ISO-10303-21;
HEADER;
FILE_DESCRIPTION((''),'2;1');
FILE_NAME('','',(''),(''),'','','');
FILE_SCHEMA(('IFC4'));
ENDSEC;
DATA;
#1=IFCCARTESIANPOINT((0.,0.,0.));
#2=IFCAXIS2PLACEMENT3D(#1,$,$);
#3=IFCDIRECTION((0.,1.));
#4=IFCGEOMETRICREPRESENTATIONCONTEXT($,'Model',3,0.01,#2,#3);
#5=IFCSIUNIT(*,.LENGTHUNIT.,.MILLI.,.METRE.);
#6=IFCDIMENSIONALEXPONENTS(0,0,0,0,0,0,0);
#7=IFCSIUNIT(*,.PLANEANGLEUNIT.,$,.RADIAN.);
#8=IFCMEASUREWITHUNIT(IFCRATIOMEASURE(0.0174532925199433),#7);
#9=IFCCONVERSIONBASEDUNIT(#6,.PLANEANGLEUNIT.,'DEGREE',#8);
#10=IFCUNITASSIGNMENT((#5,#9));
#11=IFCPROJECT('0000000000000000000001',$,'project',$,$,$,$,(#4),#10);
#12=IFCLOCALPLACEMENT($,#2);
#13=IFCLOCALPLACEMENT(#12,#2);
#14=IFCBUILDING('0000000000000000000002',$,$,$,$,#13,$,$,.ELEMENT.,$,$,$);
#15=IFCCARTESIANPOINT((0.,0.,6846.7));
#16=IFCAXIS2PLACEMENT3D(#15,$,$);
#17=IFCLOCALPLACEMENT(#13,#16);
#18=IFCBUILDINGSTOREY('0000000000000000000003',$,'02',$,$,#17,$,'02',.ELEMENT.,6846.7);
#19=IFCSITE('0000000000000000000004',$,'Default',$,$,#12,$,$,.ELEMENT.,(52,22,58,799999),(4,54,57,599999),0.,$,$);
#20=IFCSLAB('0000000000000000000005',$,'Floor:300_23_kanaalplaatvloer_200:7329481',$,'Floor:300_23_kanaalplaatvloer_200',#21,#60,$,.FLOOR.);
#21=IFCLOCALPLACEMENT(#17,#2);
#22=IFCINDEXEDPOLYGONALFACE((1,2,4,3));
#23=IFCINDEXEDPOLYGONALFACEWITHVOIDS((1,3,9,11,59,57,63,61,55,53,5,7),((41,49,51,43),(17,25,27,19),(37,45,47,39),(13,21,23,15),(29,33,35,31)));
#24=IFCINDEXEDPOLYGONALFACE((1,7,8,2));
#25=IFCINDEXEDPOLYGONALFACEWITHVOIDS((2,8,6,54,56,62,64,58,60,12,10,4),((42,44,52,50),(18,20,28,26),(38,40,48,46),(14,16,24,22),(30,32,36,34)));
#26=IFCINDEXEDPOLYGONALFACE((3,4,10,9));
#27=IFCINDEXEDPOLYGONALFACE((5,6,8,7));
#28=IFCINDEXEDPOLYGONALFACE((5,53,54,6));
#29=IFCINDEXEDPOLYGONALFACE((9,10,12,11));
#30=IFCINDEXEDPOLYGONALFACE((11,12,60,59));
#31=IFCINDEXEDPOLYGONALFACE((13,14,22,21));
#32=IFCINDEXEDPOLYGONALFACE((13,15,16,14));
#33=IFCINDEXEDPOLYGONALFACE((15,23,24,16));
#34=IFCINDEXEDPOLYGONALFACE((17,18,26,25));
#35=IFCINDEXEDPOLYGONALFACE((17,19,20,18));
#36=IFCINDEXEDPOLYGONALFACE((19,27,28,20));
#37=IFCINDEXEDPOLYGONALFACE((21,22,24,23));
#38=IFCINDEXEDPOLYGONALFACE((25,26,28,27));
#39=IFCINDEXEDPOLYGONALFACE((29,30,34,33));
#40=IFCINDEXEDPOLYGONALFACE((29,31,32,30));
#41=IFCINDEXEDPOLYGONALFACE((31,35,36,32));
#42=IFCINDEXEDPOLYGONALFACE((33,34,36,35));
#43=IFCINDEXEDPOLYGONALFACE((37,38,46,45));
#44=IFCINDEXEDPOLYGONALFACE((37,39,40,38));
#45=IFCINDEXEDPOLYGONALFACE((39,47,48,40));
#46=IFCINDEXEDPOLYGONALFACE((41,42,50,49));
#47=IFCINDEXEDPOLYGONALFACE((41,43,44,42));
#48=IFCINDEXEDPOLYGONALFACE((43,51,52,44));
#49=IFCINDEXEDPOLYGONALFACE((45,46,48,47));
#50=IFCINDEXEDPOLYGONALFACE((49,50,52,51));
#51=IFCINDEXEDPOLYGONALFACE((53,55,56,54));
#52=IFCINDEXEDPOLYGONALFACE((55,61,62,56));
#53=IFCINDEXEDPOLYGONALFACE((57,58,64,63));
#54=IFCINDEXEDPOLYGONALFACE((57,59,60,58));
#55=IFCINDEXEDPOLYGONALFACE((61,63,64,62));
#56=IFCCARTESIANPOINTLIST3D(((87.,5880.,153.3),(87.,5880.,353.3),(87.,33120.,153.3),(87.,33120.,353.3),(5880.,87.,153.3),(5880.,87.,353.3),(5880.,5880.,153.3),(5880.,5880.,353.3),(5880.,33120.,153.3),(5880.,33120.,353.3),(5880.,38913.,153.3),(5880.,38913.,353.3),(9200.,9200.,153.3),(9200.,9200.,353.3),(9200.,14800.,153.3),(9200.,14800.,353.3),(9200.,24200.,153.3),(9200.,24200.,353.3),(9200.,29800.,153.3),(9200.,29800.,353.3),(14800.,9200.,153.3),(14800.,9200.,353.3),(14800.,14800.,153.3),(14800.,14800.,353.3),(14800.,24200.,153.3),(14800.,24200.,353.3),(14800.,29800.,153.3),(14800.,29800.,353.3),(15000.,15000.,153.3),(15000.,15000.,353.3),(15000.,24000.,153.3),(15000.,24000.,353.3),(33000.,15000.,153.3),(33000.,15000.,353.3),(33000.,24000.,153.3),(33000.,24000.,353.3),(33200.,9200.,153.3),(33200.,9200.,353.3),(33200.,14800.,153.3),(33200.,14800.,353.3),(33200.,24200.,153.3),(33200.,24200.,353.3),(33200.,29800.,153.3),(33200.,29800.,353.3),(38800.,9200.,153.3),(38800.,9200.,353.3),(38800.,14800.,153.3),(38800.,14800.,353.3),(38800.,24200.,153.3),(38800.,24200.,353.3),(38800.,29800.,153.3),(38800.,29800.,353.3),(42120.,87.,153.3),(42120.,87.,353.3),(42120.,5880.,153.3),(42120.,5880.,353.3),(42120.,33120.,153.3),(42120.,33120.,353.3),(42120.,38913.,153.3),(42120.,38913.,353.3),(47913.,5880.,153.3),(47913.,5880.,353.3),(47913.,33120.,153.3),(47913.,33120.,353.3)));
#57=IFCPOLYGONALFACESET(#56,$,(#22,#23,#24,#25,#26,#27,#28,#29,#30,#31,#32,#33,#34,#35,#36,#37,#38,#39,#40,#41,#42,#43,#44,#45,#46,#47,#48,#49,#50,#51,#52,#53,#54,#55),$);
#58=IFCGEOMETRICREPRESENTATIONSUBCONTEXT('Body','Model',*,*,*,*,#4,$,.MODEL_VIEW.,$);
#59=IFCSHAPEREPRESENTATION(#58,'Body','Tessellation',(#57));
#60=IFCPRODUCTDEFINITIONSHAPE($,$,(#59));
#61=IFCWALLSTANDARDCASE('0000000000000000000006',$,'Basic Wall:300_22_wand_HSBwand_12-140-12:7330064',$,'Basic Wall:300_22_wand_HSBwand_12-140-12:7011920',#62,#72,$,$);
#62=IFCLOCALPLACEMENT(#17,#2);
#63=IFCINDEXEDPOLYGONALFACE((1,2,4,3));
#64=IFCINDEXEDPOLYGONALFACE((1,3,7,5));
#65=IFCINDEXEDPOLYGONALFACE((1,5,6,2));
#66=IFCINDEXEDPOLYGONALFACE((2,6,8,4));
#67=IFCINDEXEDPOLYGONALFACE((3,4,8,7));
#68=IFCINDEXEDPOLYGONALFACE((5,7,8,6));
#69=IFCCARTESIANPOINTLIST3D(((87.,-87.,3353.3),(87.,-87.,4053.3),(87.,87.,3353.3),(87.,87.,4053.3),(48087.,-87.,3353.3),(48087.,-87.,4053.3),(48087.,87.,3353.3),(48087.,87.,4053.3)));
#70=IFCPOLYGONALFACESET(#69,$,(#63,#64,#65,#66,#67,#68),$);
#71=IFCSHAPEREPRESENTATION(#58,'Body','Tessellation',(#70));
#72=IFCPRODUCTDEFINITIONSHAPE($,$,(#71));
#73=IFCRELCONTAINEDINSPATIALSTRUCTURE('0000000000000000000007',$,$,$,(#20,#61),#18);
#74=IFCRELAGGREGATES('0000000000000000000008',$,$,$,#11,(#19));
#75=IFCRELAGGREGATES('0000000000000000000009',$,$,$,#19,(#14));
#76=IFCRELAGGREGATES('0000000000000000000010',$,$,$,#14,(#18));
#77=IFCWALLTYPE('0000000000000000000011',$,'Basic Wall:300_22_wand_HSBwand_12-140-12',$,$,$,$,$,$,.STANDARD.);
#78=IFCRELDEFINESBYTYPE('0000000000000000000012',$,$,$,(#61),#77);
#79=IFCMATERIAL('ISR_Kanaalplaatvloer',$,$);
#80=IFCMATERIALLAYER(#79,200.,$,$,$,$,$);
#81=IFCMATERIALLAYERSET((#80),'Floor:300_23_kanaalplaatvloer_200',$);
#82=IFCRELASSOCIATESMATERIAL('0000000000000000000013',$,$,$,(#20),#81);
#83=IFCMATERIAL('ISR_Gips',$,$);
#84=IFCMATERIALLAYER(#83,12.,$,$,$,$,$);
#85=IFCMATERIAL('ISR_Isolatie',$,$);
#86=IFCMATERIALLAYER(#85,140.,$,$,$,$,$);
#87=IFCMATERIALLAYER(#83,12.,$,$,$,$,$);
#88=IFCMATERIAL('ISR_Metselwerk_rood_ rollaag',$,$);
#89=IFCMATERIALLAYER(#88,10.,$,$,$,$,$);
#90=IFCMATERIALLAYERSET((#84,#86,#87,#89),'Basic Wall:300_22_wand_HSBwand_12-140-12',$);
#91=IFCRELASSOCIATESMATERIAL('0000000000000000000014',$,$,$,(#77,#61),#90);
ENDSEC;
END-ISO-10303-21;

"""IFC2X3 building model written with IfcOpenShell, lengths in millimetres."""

from ifc_helpers import new_model, entity, si_unit, converted_unit, direction, frame, frame_2d, origin, origin_2d_with_axis, place, context, subcontext, project, spatial, polyline, rectangle, outline, extrude, material, layer, layer_set, layer_usage, type_object, element, save


model = new_model("IFC2X3")

# Units and contexts
model_context = context("Model", 3, precision=0.01, world=origin(), true_north=direction((0.0, 1.0)))
body_context = subcontext(model_context, "Body", "Model", "MODEL_VIEW")
ifc_project = project(units=[si_unit("LENGTHUNIT", "METRE", prefix="MILLI"), converted_unit("PLANEANGLEUNIT", "DEGREE", entity("IfcRatioMeasure", 0.0174532925199433), si_unit("PLANEANGLEUNIT", "RADIAN"), dimensions=[0, 0, 0, 0, 0, 0, 0])], contexts=[model_context])

# Site, building, storey
site_placement = place(None, origin())
site = spatial("IfcSite", under=ifc_project, at=site_placement, Name="Default", CompositionType="ELEMENT", RefLatitude=(52, 22, 58, 799999), RefLongitude=(4, 54, 57, 599999), RefElevation=0.0)
building_placement = place(site_placement, origin())
building = spatial("IfcBuilding", under=site, at=building_placement, CompositionType="ELEMENT")
storey_placement = place(building_placement, frame((0.0, 0.0, 6846.7)))
storey = spatial("IfcBuildingStorey", under=building, at=storey_placement, Name="02", LongName="02", CompositionType="ELEMENT", Elevation=6846.7)

# Slab, openings
ifc_material_1 = material(Name="ISR_Kanaalplaatvloer")
ifc_layer_1 = layer(ifc_material_1, 200.0)
ifc_layer_set_1 = layer_set([ifc_layer_1], Name="Floor:300_23_kanaalplaatvloer_200")
ifc_layer_usage_1 = layer_usage(ifc_layer_set_1, "AXIS3", "POSITIVE", 0.0)
slab_placement = place(storey_placement, frame((87.0, 87.0, 153.3)))
slab = element("IfcSlab", 1, at=slab_placement, inside=storey, material=ifc_layer_usage_1, Name="Floor:300_23_kanaalplaatvloer_200:7329481", ObjectType="Floor:300_23_kanaalplaatvloer_200", PredefinedType="FLOOR", context=body_context, shape_type="SweptSolid", body=[
    extrude(outline(polyline([(-18120.0, 19413.0), (-18120.0, 13620.0), (-23913.0, 13620.0), (-23913.0, -13620.0), (-18120.0, -13620.0), (-18120.0, -19413.0), (18120.0, -19413.0), (18120.0, -13620.0), (23913.0, -13620.0), (23913.0, 13620.0), (18120.0, 13620.0), (18120.0, 19413.0), (-18120.0, 19413.0)])), frame((23913.0, 19413.0, 200.0), z_axis=(0.0, 0.0, -1.0), x_axis=(-1.0, 0.0, 0.0)), (0.0, 0.0, 1.0), 200.0),
])
opening_1_placement = place(slab_placement, frame((23913.0, 19413.0, 200.0)))
element("IfcOpeningElement", 2, at=opening_1_placement, cuts=slab, ObjectType="Opening", context=body_context, shape_type="SweptSolid", body=[
    extrude(rectangle(XDim=18000.0, YDim=9000.0, at=origin_2d_with_axis()), frame((0.0, 0.0, 0.0), z_axis=(0.0, 0.0, -1.0), x_axis=(1.0, 0.0, 0.0)), (0.0, 0.0, 1.0), 200.0),
])
opening_2_placement = place(slab_placement, frame((11913.0, 11913.0, 200.0)))
element("IfcOpeningElement", 3, at=opening_2_placement, cuts=slab, ObjectType="Opening", context=body_context, shape_type="SweptSolid", body=[
    extrude(rectangle(XDim=5600.0, YDim=5600.0, at=origin_2d_with_axis()), frame((0.0, 0.0, 0.0), z_axis=(0.0, 0.0, -1.0), x_axis=(1.0, 0.0, 0.0)), (0.0, 0.0, 1.0), 200.0),
])
opening_3_placement = place(slab_placement, frame((11913.0, 26913.0, 200.0)))
element("IfcOpeningElement", 4, at=opening_3_placement, cuts=slab, ObjectType="Opening", context=body_context, shape_type="SweptSolid", body=[
    extrude(rectangle(XDim=5600.0, YDim=5600.0, at=origin_2d_with_axis()), frame((0.0, 0.0, 0.0), z_axis=(0.0, 0.0, -1.0), x_axis=(1.0, 0.0, 0.0)), (0.0, 0.0, 1.0), 200.0),
])
opening_4_placement = place(slab_placement, frame((35913.0, 26913.0, 200.0)))
element("IfcOpeningElement", 5, at=opening_4_placement, cuts=slab, ObjectType="Opening", context=body_context, shape_type="SweptSolid", body=[
    extrude(rectangle(XDim=5600.0, YDim=5600.0, at=origin_2d_with_axis()), frame((0.0, 0.0, 0.0), z_axis=(0.0, 0.0, -1.0), x_axis=(1.0, 0.0, 0.0)), (0.0, 0.0, 1.0), 200.0),
])
opening_5_placement = place(slab_placement, frame((35913.0, 11913.0, 200.0)))
element("IfcOpeningElement", 6, at=opening_5_placement, cuts=slab, ObjectType="Opening", context=body_context, shape_type="SweptSolid", body=[
    extrude(rectangle(XDim=5600.0, YDim=5600.0, at=origin_2d_with_axis()), frame((0.0, 0.0, 0.0), z_axis=(0.0, 0.0, -1.0), x_axis=(1.0, 0.0, 0.0)), (0.0, 0.0, 1.0), 200.0),
])

# Wall
ifc_material_2 = material(Name="ISR_Gips")
ifc_layer_2 = layer(ifc_material_2, 12.0)
ifc_material_3 = material(Name="ISR_Isolatie")
ifc_layer_3 = layer(ifc_material_3, 140.0)
ifc_layer_4 = layer(ifc_material_2, 12.0)
ifc_material_4 = material(Name="ISR_Metselwerk_rood_ rollaag")
ifc_layer_5 = layer(ifc_material_4, 10.0)
ifc_layer_set_2 = layer_set([ifc_layer_2, ifc_layer_3, ifc_layer_4, ifc_layer_5], Name="Basic Wall:300_22_wand_HSBwand_12-140-12")
ifc_layer_usage_2 = layer_usage(ifc_layer_set_2, "AXIS2", "NEGATIVE", 87.0)
wall_type_1 = type_object("IfcWallType", Name="Basic Wall:300_22_wand_HSBwand_12-140-12", PredefinedType="STANDARD", material=ifc_layer_set_2)
wall_1_placement = place(storey_placement, frame((87.0, 0.0, 3353.3)))
element("IfcWallStandardCase", 7, at=wall_1_placement, inside=storey, type_object=wall_type_1, material=ifc_layer_usage_2, Name="Basic Wall:300_22_wand_HSBwand_12-140-12:7330064", ObjectType="Basic Wall:300_22_wand_HSBwand_12-140-12:7011920", context=body_context, shape_type="SweptSolid", body=[
    extrude(rectangle(XDim=48000.0, YDim=174.0, at=frame_2d((24000.0, 0.0), x_axis=(-1.0, 0.0))), origin(), (0.0, 0.0, 1.0), 700.0),
])

save(model, "model.ifc")
